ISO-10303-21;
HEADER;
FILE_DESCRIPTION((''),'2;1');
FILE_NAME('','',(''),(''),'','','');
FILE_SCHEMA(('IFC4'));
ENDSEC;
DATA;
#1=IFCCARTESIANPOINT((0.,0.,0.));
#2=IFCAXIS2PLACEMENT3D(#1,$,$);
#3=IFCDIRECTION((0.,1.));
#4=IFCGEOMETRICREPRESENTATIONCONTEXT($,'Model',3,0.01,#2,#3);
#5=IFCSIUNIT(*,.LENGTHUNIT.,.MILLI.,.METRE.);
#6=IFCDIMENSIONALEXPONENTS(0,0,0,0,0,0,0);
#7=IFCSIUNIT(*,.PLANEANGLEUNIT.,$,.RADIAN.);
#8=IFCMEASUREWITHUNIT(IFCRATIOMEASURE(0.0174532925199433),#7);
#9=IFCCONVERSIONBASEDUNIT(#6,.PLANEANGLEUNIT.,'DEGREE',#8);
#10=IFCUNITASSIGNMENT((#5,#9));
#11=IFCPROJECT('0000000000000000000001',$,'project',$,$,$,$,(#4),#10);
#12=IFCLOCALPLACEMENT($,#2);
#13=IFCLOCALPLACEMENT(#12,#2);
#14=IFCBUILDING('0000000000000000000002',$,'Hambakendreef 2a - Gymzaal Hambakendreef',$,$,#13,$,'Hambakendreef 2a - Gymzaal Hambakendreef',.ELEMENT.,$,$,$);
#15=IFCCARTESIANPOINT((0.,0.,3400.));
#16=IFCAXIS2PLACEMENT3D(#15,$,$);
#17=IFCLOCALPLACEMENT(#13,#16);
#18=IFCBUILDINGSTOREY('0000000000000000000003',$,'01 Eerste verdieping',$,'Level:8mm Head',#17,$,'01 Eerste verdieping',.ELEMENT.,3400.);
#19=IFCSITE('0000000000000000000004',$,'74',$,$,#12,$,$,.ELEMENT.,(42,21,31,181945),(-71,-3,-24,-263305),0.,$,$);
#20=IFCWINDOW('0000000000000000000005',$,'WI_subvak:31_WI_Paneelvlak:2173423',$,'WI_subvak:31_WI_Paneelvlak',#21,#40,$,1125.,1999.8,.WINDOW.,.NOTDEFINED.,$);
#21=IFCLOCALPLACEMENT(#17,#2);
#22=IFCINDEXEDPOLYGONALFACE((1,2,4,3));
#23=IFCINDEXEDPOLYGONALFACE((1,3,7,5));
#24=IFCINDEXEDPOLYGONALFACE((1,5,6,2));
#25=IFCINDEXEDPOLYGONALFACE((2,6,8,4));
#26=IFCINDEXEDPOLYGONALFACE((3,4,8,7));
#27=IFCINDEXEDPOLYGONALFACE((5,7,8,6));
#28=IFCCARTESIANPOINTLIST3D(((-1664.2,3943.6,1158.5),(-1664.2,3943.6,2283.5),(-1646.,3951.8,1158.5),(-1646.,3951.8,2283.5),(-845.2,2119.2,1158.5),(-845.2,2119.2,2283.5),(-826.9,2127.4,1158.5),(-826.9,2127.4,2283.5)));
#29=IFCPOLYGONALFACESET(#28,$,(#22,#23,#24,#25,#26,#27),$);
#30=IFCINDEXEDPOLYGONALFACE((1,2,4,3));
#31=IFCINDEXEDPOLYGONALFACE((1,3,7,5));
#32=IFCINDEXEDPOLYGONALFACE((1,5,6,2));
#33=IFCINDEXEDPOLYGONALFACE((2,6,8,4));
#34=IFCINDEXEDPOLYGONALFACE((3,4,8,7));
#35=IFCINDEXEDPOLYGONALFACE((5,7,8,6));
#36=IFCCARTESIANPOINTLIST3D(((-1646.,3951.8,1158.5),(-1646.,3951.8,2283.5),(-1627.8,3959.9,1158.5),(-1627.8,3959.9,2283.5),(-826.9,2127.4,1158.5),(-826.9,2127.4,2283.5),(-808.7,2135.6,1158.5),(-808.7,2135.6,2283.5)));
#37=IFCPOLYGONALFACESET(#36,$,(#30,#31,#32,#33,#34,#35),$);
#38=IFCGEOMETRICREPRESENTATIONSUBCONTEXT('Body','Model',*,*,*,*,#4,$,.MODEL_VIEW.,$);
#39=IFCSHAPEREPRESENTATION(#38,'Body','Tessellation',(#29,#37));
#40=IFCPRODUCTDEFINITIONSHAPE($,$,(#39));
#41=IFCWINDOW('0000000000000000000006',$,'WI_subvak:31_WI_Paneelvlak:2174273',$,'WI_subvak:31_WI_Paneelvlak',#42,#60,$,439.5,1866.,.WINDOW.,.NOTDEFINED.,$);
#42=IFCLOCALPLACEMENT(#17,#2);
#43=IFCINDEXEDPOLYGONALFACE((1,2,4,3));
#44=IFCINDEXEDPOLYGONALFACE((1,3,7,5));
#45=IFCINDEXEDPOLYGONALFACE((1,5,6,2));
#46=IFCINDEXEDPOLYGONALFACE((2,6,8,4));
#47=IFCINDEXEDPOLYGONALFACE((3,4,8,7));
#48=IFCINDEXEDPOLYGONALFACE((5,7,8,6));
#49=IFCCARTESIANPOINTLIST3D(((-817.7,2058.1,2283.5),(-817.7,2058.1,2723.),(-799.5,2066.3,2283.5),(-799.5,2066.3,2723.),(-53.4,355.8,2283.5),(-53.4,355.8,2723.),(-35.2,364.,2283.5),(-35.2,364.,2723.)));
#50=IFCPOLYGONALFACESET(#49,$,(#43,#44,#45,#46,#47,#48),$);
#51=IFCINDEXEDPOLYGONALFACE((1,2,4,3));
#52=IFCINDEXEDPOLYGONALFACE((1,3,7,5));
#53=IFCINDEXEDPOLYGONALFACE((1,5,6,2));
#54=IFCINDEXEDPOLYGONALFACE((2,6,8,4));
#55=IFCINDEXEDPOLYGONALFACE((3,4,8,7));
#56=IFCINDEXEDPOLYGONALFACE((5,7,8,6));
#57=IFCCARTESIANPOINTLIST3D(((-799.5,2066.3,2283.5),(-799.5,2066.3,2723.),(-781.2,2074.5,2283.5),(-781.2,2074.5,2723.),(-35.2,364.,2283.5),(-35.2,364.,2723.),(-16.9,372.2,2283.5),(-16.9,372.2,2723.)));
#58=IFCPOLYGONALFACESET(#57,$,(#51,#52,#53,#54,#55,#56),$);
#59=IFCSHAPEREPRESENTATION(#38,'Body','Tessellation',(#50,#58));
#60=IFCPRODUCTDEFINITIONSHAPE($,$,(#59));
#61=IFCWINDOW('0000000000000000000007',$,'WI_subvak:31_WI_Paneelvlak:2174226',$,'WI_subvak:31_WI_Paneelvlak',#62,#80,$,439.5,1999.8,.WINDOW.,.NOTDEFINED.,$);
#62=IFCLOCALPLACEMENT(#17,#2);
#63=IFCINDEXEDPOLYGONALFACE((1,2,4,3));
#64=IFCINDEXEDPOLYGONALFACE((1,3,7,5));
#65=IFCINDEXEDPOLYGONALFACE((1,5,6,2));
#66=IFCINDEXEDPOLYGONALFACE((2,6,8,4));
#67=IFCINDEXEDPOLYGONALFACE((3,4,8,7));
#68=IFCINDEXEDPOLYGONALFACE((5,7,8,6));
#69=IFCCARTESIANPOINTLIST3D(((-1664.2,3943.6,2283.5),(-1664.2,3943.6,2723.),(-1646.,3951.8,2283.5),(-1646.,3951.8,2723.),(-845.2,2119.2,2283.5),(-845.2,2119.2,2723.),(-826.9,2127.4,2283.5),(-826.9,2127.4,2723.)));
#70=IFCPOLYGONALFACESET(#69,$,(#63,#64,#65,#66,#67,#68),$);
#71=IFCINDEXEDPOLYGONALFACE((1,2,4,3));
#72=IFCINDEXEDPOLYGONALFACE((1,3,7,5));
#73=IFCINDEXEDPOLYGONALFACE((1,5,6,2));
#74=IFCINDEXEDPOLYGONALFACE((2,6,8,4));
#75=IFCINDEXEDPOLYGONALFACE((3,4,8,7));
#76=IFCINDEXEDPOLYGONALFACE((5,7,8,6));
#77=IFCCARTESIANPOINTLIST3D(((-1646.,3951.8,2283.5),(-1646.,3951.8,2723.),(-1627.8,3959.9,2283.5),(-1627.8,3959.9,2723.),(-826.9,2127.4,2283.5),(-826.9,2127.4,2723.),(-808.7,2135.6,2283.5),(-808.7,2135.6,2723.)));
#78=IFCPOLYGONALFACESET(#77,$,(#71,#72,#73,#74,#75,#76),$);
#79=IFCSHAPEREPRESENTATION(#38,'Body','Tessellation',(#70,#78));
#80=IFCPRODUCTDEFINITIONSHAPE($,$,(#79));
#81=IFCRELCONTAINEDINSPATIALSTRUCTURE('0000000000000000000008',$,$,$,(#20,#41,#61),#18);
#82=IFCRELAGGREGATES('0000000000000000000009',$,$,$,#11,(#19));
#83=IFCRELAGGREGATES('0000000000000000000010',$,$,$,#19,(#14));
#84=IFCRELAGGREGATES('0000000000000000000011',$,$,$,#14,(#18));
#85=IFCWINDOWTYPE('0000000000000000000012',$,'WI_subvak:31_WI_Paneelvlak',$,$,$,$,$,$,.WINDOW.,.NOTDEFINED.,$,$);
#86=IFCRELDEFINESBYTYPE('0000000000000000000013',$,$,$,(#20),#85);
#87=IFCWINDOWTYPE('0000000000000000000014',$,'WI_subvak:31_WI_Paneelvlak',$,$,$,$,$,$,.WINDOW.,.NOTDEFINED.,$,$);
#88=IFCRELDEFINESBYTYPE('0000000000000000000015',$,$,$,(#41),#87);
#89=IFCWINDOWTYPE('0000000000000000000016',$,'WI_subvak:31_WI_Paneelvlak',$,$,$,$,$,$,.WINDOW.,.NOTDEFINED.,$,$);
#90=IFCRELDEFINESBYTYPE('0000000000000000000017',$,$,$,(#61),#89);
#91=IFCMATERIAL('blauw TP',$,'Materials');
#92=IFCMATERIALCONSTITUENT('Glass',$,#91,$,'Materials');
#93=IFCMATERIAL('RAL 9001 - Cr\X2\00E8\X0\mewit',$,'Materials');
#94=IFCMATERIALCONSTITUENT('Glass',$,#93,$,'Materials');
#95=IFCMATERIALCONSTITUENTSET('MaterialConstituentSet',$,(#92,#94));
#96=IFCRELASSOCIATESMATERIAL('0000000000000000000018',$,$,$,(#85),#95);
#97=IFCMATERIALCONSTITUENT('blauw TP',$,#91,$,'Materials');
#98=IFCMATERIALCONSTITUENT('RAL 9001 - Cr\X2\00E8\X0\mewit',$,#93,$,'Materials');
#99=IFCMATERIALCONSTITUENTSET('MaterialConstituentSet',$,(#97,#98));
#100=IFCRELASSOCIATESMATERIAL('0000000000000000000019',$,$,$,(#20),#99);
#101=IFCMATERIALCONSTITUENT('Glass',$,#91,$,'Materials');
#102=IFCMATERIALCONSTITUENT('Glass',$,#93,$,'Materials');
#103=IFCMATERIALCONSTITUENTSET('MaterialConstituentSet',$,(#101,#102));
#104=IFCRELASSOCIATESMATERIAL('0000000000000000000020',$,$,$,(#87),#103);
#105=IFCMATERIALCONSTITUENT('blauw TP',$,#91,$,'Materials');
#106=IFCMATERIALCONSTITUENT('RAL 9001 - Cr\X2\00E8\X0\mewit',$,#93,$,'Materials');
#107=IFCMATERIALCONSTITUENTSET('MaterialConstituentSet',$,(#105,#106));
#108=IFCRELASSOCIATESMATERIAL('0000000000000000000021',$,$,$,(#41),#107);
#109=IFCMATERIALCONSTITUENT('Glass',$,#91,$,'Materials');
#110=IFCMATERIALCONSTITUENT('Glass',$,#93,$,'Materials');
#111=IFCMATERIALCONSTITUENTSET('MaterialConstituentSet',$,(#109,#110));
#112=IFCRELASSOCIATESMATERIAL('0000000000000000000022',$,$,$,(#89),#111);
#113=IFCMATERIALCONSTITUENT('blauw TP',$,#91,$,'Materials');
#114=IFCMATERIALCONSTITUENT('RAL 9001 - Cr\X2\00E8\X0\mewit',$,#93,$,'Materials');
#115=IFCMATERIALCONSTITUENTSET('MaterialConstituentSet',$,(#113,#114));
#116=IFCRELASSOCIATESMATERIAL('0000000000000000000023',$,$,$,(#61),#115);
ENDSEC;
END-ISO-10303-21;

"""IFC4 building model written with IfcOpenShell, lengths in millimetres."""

from ifc_helpers import new_model, entity, si_unit, converted_unit, direction, frame, origin, place, context, subcontext, project, spatial, indexed_curve, outline, extrude, source, transform, mapped, material, constituent, constituent_set, type_object, type_shapes, element, save


model = new_model("IFC4")

# Units and contexts
model_context = context("Model", 3, precision=0.01, world=origin(), true_north=direction((0.0, 1.0)))
body_context = subcontext(model_context, "Body", "Model", "MODEL_VIEW")
ifc_project = project(units=[si_unit("LENGTHUNIT", "METRE", prefix="MILLI"), converted_unit("PLANEANGLEUNIT", "DEGREE", entity("IfcRatioMeasure", 0.0174532925199433), si_unit("PLANEANGLEUNIT", "RADIAN"), dimensions=[0, 0, 0, 0, 0, 0, 0])], contexts=[model_context])

# Site, building, storey
site_placement = place(None, origin())
site = spatial("IfcSite", under=ifc_project, at=site_placement, Name="74", CompositionType="ELEMENT", RefLatitude=(42, 21, 31, 181945), RefLongitude=(-71, -3, -24, -263305), RefElevation=0.0)
building_placement = place(site_placement, origin())
building = spatial("IfcBuilding", under=site, at=building_placement, Name="Hambakendreef 2a - Gymzaal Hambakendreef", LongName="Hambakendreef 2a - Gymzaal Hambakendreef", CompositionType="ELEMENT")
storey_placement = place(building_placement, frame((0.0, 0.0, 3400.0)))
storey = spatial("IfcBuildingStorey", under=building, at=storey_placement, Name="01 Eerste verdieping", ObjectType="Level:8mm Head", LongName="01 Eerste verdieping", CompositionType="ELEMENT", Elevation=3400.0)

# Windows
ifc_material_1 = material(Name="blauw TP", Category="Materials")
ifc_material_2 = material(Name="RAL 9001 - Crèmewit", Category="Materials")
ifc_constituent_1 = constituent(ifc_material_1, Name="blauw TP", Category="Materials")
ifc_constituent_2 = constituent(ifc_material_2, Name="RAL 9001 - Crèmewit", Category="Materials")
ifc_constituent_set_1 = constituent_set(constituents=[ifc_constituent_1, ifc_constituent_2], Name="MaterialConstituentSet")
ifc_constituent_3 = constituent(ifc_material_1, Name="Glass", Category="Materials")
ifc_constituent_4 = constituent(ifc_material_2, Name="Glass", Category="Materials")
ifc_constituent_set_2 = constituent_set(constituents=[ifc_constituent_3, ifc_constituent_4], Name="MaterialConstituentSet")
window_type_1 = type_object("IfcWindowType", Name="WI_subvak:31_WI_Paneelvlak", PartitioningType="NOTDEFINED", PredefinedType="WINDOW", material=ifc_constituent_set_2)
shared_shape_1 = source(origin(), body_context, "Body", "SweptSolid", [
    extrude(outline(indexed_curve([(-999.9, -10.0), (999.9, -10.0), (999.9, 10.0), (-999.9, 10.0), (-999.9, -10.0)], self_intersect=False)), frame((0.0, -10.0, 0.0)), (0.0, 0.0, 1.0), 1125.0),
    extrude(outline(indexed_curve([(-999.9, -10.0), (999.9, -10.0), (999.9, 10.0), (-999.9, 10.0), (-999.9, -10.0)], self_intersect=False)), frame((0.0, 10.0, 0.0)), (0.0, 0.0, 1.0), 1125.0),
])
type_shapes(window_type_1, [shared_shape_1])
window_1_placement = place(storey_placement, frame((-1236.5, 3039.6, 1158.5), z_axis=(0.0, 0.0, 1.0), x_axis=(0.40959, -0.91227, 0.0)))
element("IfcWindow", 1, at=window_1_placement, inside=storey, type_object=window_type_1, material=ifc_constituent_set_1, Name="WI_subvak:31_WI_Paneelvlak:2173423", ObjectType="WI_subvak:31_WI_Paneelvlak", OverallHeight=1125.0, OverallWidth=1999.8, PartitioningType="NOTDEFINED", PredefinedType="WINDOW", context=body_context, shape_type="MappedRepresentation", body=[
    mapped(shared_shape_1, transform((0.0, 0.0, 0.0), scale=1.0)),
])
ifc_constituent_5 = constituent(ifc_material_1, Name="blauw TP", Category="Materials")
ifc_constituent_6 = constituent(ifc_material_2, Name="RAL 9001 - Crèmewit", Category="Materials")
ifc_constituent_set_3 = constituent_set(constituents=[ifc_constituent_5, ifc_constituent_6], Name="MaterialConstituentSet")
ifc_constituent_7 = constituent(ifc_material_1, Name="Glass", Category="Materials")
ifc_constituent_8 = constituent(ifc_material_2, Name="Glass", Category="Materials")
ifc_constituent_set_4 = constituent_set(constituents=[ifc_constituent_7, ifc_constituent_8], Name="MaterialConstituentSet")
window_type_2 = type_object("IfcWindowType", Name="WI_subvak:31_WI_Paneelvlak", PartitioningType="NOTDEFINED", PredefinedType="WINDOW", material=ifc_constituent_set_4)
shared_shape_2 = source(origin(), body_context, "Body", "SweptSolid", [
    extrude(outline(indexed_curve([(-933.0, -10.0), (933.0, -10.0), (933.0, 10.0), (-933.0, 10.0), (-933.0, -10.0)], self_intersect=False)), frame((0.0, -10.0, 0.0)), (0.0, 0.0, 1.0), 439.5),
    extrude(outline(indexed_curve([(-933.0, -10.0), (933.0, -10.0), (933.0, 10.0), (-933.0, 10.0), (-933.0, -10.0)], self_intersect=False)), frame((0.0, 10.0, 0.0)), (0.0, 0.0, 1.0), 439.5),
])
type_shapes(window_type_2, [shared_shape_2])
window_2_placement = place(storey_placement, frame((-417.3, 1215.2, 2283.5), z_axis=(0.0, 0.0, 1.0), x_axis=(0.40959, -0.91227, 0.0)))
element("IfcWindow", 2, at=window_2_placement, inside=storey, type_object=window_type_2, material=ifc_constituent_set_3, Name="WI_subvak:31_WI_Paneelvlak:2174273", ObjectType="WI_subvak:31_WI_Paneelvlak", OverallHeight=439.5, OverallWidth=1866.0, PartitioningType="NOTDEFINED", PredefinedType="WINDOW", context=body_context, shape_type="MappedRepresentation", body=[
    mapped(shared_shape_2, transform((0.0, 0.0, 0.0), scale=1.0)),
])
ifc_constituent_9 = constituent(ifc_material_1, Name="blauw TP", Category="Materials")
ifc_constituent_10 = constituent(ifc_material_2, Name="RAL 9001 - Crèmewit", Category="Materials")
ifc_constituent_set_5 = constituent_set(constituents=[ifc_constituent_9, ifc_constituent_10], Name="MaterialConstituentSet")
ifc_constituent_11 = constituent(ifc_material_1, Name="Glass", Category="Materials")
ifc_constituent_12 = constituent(ifc_material_2, Name="Glass", Category="Materials")
ifc_constituent_set_6 = constituent_set(constituents=[ifc_constituent_11, ifc_constituent_12], Name="MaterialConstituentSet")
window_type_3 = type_object("IfcWindowType", Name="WI_subvak:31_WI_Paneelvlak", PartitioningType="NOTDEFINED", PredefinedType="WINDOW", material=ifc_constituent_set_6)
shared_shape_3 = source(origin(), body_context, "Body", "SweptSolid", [
    extrude(outline(indexed_curve([(-999.9, -10.0), (999.9, -10.0), (999.9, 10.0), (-999.9, 10.0), (-999.9, -10.0)], self_intersect=False)), frame((0.0, -10.0, 0.0)), (0.0, 0.0, 1.0), 439.5),
    extrude(outline(indexed_curve([(-999.9, -10.0), (999.9, -10.0), (999.9, 10.0), (-999.9, 10.0), (-999.9, -10.0)], self_intersect=False)), frame((0.0, 10.0, 0.0)), (0.0, 0.0, 1.0), 439.5),
])
type_shapes(window_type_3, [shared_shape_3])
window_3_placement = place(storey_placement, frame((-1236.5, 3039.6, 2283.5), z_axis=(0.0, 0.0, 1.0), x_axis=(0.40959, -0.91227, 0.0)))
element("IfcWindow", 3, at=window_3_placement, inside=storey, type_object=window_type_3, material=ifc_constituent_set_5, Name="WI_subvak:31_WI_Paneelvlak:2174226", ObjectType="WI_subvak:31_WI_Paneelvlak", OverallHeight=439.5, OverallWidth=1999.8, PartitioningType="NOTDEFINED", PredefinedType="WINDOW", context=body_context, shape_type="MappedRepresentation", body=[
    mapped(shared_shape_3, transform((0.0, 0.0, 0.0), scale=1.0)),
])

save(model, "model.ifc")
